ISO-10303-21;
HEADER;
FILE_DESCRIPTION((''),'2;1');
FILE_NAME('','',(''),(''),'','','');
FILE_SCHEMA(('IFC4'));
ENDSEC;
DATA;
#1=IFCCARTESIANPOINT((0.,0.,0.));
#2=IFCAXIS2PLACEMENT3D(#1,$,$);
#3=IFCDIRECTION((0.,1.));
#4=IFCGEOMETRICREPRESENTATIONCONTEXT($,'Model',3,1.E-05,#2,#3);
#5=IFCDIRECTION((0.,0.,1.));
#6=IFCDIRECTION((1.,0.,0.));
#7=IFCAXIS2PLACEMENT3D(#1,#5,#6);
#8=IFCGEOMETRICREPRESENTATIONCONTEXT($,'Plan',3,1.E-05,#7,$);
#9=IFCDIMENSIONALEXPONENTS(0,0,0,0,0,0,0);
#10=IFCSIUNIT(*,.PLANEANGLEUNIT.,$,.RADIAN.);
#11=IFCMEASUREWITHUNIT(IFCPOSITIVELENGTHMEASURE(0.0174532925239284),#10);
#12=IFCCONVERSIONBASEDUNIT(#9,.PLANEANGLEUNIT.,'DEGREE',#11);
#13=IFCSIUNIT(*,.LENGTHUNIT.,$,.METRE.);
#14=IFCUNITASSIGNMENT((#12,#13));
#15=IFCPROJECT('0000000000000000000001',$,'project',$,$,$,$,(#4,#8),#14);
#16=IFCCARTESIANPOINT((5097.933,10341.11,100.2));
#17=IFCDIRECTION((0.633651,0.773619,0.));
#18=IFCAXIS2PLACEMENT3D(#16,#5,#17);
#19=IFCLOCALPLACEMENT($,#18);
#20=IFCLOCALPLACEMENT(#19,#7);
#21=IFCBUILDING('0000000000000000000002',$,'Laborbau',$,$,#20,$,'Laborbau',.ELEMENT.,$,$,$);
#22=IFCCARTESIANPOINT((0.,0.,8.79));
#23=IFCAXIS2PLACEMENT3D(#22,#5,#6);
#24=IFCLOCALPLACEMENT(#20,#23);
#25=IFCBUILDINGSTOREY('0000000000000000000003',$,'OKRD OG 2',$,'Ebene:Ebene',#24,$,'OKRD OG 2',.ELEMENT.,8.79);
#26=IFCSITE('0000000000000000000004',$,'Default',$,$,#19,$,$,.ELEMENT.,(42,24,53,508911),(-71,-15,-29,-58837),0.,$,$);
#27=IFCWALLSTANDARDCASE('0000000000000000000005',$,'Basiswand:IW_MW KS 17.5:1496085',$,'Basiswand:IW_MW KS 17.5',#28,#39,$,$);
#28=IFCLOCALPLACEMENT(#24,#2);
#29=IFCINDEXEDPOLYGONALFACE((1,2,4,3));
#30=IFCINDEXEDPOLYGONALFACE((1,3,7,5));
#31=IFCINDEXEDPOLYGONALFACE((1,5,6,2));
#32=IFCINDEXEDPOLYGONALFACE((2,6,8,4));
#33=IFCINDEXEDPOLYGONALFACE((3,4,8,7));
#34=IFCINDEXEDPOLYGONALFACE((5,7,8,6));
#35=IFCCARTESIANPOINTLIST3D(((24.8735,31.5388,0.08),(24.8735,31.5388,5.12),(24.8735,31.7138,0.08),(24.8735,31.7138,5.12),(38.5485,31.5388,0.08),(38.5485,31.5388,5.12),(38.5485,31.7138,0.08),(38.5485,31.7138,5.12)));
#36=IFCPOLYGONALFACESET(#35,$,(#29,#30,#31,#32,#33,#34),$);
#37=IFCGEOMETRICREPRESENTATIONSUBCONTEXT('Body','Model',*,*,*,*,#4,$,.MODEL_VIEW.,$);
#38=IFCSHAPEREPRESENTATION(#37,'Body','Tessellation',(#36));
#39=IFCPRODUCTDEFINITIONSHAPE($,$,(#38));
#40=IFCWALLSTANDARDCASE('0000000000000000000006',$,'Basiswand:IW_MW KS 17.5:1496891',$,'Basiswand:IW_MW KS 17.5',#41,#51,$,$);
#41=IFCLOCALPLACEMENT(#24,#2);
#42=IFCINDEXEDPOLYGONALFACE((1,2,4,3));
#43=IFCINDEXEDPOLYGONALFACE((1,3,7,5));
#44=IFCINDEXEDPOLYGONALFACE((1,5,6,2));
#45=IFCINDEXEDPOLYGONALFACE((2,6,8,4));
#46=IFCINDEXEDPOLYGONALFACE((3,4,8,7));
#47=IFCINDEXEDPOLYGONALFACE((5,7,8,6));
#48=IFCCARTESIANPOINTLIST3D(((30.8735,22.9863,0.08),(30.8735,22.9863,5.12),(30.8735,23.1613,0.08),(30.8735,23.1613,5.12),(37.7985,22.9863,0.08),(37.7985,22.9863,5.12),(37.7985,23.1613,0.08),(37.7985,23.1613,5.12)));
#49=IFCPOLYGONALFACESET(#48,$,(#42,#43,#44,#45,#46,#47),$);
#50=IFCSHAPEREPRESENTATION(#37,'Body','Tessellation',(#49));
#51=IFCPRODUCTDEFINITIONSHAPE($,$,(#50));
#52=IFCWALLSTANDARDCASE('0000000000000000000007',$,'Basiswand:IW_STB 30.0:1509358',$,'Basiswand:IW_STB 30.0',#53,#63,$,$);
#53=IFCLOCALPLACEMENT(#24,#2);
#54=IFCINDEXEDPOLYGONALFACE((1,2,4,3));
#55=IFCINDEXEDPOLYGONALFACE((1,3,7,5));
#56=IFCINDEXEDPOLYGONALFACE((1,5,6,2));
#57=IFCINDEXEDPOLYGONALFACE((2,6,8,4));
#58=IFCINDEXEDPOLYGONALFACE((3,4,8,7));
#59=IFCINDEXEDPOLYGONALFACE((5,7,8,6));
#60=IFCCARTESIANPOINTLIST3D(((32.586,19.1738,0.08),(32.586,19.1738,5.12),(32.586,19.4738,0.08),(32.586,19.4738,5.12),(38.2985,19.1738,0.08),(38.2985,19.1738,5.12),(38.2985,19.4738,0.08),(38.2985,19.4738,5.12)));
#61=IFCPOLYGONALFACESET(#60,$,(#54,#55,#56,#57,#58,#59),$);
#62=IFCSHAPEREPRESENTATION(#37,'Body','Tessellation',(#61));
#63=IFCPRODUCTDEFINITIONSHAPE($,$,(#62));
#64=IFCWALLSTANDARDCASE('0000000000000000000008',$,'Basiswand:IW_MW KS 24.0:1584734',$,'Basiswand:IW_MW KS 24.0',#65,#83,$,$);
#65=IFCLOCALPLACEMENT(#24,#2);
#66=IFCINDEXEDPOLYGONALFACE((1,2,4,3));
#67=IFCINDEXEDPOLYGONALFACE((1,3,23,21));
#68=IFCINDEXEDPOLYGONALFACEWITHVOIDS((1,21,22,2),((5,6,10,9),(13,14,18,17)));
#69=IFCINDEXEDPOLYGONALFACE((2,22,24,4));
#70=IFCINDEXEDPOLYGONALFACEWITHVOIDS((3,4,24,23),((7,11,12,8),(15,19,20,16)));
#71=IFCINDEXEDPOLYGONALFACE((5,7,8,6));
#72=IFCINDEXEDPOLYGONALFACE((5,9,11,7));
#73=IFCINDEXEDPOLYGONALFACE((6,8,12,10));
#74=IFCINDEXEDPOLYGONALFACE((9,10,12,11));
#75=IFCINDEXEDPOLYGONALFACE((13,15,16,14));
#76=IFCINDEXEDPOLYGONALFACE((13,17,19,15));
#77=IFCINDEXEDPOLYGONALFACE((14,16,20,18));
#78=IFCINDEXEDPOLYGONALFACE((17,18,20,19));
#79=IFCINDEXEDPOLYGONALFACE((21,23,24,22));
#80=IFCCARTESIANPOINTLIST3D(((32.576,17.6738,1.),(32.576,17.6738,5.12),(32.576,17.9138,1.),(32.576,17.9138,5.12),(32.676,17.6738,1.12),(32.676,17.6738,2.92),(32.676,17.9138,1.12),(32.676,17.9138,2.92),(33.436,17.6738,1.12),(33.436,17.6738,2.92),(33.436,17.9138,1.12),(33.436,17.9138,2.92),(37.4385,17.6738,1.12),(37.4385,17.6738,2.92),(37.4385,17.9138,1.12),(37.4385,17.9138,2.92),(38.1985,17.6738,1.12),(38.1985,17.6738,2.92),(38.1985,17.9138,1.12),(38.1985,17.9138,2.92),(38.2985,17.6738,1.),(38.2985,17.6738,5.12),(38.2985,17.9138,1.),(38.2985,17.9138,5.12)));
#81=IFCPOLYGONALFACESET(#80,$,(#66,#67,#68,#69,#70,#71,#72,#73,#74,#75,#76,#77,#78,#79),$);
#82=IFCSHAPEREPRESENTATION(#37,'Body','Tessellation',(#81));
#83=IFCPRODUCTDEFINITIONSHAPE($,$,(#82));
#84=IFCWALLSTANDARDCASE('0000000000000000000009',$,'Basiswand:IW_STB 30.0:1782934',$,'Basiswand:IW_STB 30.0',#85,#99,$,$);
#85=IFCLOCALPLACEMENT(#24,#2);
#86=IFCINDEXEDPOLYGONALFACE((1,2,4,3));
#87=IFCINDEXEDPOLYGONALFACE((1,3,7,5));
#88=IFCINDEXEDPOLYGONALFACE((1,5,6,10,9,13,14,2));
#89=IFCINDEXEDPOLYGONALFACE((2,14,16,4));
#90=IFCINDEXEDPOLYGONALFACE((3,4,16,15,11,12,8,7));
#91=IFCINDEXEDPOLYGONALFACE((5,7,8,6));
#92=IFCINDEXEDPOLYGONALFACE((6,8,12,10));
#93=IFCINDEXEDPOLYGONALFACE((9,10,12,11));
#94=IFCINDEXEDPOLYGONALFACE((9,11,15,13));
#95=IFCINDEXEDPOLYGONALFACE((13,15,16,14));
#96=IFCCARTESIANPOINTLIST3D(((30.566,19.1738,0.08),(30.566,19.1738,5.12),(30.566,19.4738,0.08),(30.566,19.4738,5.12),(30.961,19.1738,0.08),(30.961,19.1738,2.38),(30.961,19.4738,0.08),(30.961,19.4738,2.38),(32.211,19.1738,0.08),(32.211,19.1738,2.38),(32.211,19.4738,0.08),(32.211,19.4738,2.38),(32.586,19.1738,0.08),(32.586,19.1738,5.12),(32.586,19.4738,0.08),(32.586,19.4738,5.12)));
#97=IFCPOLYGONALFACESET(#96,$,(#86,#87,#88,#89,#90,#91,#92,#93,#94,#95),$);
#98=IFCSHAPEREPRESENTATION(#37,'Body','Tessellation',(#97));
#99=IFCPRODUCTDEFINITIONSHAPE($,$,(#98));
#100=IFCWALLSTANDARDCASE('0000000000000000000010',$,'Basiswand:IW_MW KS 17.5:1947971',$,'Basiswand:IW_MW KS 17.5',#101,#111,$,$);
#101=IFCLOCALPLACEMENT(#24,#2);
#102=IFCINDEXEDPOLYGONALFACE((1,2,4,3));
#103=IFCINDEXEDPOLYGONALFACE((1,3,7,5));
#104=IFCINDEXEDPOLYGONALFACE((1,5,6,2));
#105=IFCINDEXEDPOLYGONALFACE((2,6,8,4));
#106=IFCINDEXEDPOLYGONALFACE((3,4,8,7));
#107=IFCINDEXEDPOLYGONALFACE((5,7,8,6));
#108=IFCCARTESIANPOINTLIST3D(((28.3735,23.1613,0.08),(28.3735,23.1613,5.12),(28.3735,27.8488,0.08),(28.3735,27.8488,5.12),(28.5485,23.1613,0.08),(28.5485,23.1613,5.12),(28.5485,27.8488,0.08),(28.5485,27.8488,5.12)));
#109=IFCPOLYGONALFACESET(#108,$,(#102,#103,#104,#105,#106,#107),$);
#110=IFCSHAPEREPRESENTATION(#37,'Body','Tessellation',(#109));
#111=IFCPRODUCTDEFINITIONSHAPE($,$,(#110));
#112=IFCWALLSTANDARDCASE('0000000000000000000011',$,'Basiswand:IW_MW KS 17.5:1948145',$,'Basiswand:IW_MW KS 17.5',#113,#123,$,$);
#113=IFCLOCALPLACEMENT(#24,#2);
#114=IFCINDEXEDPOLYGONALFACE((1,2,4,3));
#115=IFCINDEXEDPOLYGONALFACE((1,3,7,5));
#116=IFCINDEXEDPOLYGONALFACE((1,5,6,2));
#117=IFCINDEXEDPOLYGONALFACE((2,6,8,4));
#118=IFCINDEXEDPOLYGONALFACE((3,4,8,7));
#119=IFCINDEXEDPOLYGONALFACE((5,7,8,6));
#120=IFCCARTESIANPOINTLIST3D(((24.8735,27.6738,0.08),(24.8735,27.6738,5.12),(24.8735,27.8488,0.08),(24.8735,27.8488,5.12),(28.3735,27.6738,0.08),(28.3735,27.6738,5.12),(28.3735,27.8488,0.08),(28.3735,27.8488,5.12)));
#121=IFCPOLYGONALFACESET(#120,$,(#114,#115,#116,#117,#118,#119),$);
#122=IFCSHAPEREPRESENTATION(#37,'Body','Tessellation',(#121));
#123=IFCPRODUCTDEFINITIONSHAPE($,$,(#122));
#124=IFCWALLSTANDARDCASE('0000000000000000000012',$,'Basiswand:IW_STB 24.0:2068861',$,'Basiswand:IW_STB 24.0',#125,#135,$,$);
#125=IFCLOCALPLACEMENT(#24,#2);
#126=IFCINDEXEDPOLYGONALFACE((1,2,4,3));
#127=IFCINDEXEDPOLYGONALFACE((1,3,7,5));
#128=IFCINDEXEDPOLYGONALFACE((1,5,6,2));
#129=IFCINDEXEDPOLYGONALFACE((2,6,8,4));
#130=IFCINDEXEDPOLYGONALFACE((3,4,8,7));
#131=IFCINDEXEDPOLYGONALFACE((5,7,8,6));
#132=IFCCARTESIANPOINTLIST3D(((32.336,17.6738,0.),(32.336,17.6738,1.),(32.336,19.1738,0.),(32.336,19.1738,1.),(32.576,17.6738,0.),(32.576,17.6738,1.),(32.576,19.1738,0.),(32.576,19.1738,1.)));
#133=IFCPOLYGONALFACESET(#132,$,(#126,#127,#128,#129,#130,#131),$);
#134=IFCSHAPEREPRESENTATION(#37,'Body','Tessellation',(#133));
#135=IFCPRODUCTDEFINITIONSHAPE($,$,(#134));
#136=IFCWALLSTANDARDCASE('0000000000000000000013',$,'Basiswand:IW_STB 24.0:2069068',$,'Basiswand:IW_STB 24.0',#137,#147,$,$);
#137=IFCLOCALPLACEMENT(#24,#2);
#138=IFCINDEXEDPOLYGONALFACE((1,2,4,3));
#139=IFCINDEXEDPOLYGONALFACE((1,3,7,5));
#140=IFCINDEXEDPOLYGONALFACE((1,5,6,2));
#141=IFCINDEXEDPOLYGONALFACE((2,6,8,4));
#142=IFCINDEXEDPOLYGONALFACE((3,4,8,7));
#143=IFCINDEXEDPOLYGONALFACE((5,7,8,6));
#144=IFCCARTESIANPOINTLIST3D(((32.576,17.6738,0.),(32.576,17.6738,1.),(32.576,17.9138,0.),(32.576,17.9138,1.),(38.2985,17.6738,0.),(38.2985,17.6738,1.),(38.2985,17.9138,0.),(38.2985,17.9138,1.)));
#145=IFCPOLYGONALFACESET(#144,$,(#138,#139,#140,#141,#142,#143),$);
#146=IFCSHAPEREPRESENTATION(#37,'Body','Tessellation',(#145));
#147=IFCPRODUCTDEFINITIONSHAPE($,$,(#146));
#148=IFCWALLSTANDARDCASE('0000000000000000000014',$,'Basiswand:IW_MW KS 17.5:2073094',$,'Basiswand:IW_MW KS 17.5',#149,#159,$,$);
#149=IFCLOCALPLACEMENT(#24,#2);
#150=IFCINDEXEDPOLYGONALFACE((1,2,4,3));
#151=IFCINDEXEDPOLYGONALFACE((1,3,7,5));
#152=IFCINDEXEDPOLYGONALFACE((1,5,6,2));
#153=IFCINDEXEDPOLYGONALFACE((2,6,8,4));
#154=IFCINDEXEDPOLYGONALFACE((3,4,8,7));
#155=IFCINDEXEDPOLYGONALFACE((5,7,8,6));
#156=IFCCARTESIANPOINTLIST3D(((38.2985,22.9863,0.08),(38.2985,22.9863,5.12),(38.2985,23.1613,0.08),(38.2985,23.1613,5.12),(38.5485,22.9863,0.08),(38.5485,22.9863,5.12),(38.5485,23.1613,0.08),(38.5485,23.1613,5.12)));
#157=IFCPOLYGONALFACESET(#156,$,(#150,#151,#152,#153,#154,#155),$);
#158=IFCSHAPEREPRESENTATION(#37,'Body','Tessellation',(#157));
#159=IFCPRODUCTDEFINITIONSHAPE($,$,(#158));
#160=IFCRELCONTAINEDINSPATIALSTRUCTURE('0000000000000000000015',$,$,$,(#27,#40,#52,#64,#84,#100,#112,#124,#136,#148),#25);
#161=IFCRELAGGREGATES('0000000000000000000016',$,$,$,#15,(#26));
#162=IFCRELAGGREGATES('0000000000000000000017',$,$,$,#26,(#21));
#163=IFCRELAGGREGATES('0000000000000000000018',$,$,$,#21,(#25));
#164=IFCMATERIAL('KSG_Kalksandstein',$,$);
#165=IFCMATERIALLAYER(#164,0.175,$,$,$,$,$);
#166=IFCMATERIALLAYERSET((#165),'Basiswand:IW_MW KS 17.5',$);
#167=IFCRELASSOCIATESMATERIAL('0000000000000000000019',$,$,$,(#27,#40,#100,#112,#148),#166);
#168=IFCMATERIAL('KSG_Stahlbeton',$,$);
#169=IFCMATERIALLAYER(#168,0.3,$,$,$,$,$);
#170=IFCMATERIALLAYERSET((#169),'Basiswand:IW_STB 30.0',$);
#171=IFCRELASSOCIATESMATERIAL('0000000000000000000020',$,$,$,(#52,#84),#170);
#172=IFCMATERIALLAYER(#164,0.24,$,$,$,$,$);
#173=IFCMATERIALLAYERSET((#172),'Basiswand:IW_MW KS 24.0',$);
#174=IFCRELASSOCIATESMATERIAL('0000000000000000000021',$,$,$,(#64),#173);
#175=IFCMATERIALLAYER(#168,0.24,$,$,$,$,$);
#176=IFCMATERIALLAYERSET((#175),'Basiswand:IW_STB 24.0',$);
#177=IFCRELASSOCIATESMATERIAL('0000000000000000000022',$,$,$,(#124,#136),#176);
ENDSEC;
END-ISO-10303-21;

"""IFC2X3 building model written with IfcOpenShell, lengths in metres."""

from ifc_helpers import new_model, entity, si_unit, converted_unit, direction, frame, frame_2d, origin, origin_with_axes, place, context, subcontext, project, spatial, rectangle, extrude, material, layer, layer_set, layer_usage, element, save


model = new_model("IFC2X3")

# Units and contexts
model_context = context("Model", 3, precision=1e-05, world=origin(), true_north=direction((0.0, 1.0)))
plan_context = context("Plan", 3, precision=1e-05, world=origin_with_axes())
body_context = subcontext(model_context, "Body", "Model", "MODEL_VIEW")
ifc_project = project(units=[converted_unit("PLANEANGLEUNIT", "DEGREE", entity("IfcPositiveLengthMeasure", 0.0174532925239284), si_unit("PLANEANGLEUNIT", "RADIAN"), dimensions=[0, 0, 0, 0, 0, 0, 0]), si_unit("LENGTHUNIT", "METRE")], contexts=[model_context, plan_context])

# Site, building, storey
site_placement = place(None, frame((5097.933, 10341.11, 100.2), z_axis=(0.0, 0.0, 1.0), x_axis=(0.633651, 0.773619, 0.0)))
site = spatial("IfcSite", under=ifc_project, at=site_placement, Name="Default", CompositionType="ELEMENT", RefLatitude=(42, 24, 53, 508911), RefLongitude=(-71, -15, -29, -58837), RefElevation=0.0)
building_placement = place(site_placement, origin_with_axes())
building = spatial("IfcBuilding", under=site, at=building_placement, Name="Laborbau", LongName="Laborbau", CompositionType="ELEMENT")
storey_placement = place(building_placement, frame((0.0, 0.0, 8.79), z_axis=(0.0, 0.0, 1.0), x_axis=(1.0, 0.0, 0.0)))
storey = spatial("IfcBuildingStorey", under=building, at=storey_placement, Name="OKRD OG 2", ObjectType="Ebene:Ebene", LongName="OKRD OG 2", CompositionType="ELEMENT", Elevation=8.79)

# Walls
ifc_material_1 = material(Name="KSG_Kalksandstein")
ifc_layer_1 = layer(ifc_material_1, 0.175)
ifc_layer_set_1 = layer_set([ifc_layer_1], Name="Basiswand:IW_MW KS 17.5")
ifc_layer_usage_1 = layer_usage(ifc_layer_set_1, "AXIS2", "NEGATIVE", 0.0875)
wall_1_placement = place(storey_placement, frame((24.8735, 31.6263, 0.08), z_axis=(0.0, 0.0, 1.0), x_axis=(1.0, 0.0, 0.0)))
element("IfcWallStandardCase", 1, at=wall_1_placement, inside=storey, material=ifc_layer_usage_1, Name="Basiswand:IW_MW KS 17.5:1496085", ObjectType="Basiswand:IW_MW KS 17.5", context=body_context, shape_type="SweptSolid", body=[
    extrude(rectangle(XDim=13.675, YDim=0.175, at=frame_2d((6.8375, 0.0), x_axis=(-1.0, 0.0))), origin(), (0.0, 0.0, 1.0), 5.04),
])
ifc_layer_usage_2 = layer_usage(ifc_layer_set_1, "AXIS2", "NEGATIVE", 0.0875)
wall_2_placement = place(storey_placement, frame((30.8735, 23.0738, 0.08), z_axis=(0.0, 0.0, 1.0), x_axis=(1.0, 0.0, 0.0)))
element("IfcWallStandardCase", 2, at=wall_2_placement, inside=storey, material=ifc_layer_usage_2, Name="Basiswand:IW_MW KS 17.5:1496891", ObjectType="Basiswand:IW_MW KS 17.5", context=body_context, shape_type="SweptSolid", body=[
    extrude(rectangle(XDim=6.925, YDim=0.175, at=frame_2d((3.4625, 0.0), x_axis=(-1.0, 0.0))), origin(), (0.0, 0.0, 1.0), 5.04),
])
ifc_material_2 = material(Name="KSG_Stahlbeton")
ifc_layer_2 = layer(ifc_material_2, 0.3)
ifc_layer_set_2 = layer_set([ifc_layer_2], Name="Basiswand:IW_STB 30.0")
ifc_layer_usage_3 = layer_usage(ifc_layer_set_2, "AXIS2", "POSITIVE", -0.15)
wall_3_placement = place(storey_placement, frame((38.2985, 19.3238, 0.08), z_axis=(0.0, 0.0, 1.0), x_axis=(-1.0, 0.0, 0.0)))
element("IfcWallStandardCase", 3, at=wall_3_placement, inside=storey, material=ifc_layer_usage_3, Name="Basiswand:IW_STB 30.0:1509358", ObjectType="Basiswand:IW_STB 30.0", context=body_context, shape_type="SweptSolid", body=[
    extrude(rectangle(XDim=5.7125, YDim=0.3, at=frame_2d((2.8563, 0.0), x_axis=(-1.0, 0.0))), origin(), (0.0, 0.0, 1.0), 5.04),
])

# Walls, openings
ifc_layer_3 = layer(ifc_material_1, 0.24)
ifc_layer_set_3 = layer_set([ifc_layer_3], Name="Basiswand:IW_MW KS 24.0")
ifc_layer_usage_4 = layer_usage(ifc_layer_set_3, "AXIS2", "POSITIVE", -0.12)
wall_4_placement = place(storey_placement, frame((32.576, 17.7938, 1.0), z_axis=(0.0, 0.0, 1.0), x_axis=(1.0, 0.0, 0.0)))
wall_4 = element("IfcWallStandardCase", 4, at=wall_4_placement, inside=storey, material=ifc_layer_usage_4, Name="Basiswand:IW_MW KS 24.0:1584734", ObjectType="Basiswand:IW_MW KS 24.0", context=body_context, shape_type="SweptSolid", body=[
    extrude(rectangle(XDim=5.7225, YDim=0.24, at=frame_2d((2.8613, 0.0), x_axis=(-1.0, 0.0))), origin(), (0.0, 0.0, 1.0), 4.12),
])
opening_1_placement = place(wall_4_placement, frame((-32.576, -17.7938, -1.0), z_axis=(0.0, 0.0, 1.0), x_axis=(1.0, 0.0, 0.0)))
element("IfcOpeningElement", 5, at=opening_1_placement, cuts=wall_4, ObjectType="Opening", context=body_context, shape_type="SweptSolid", body=[
    extrude(rectangle(XDim=1.8, YDim=0.76, at=frame_2d((0.0, 0.0), x_axis=(1.0, 0.0))), frame((37.8185, 16.3898, 2.02), z_axis=(0.0, 1.0, 0.0), x_axis=(0.0, 0.0, 1.0)), (0.0, 0.0, 1.0), 3.048),
])
opening_2_placement = place(wall_4_placement, frame((5.6225, 0.12, 0.12), z_axis=(0.0, 0.0, 1.0), x_axis=(1.0, 0.0, 0.0)))
element("IfcOpeningElement", 6, at=opening_2_placement, cuts=wall_4, ObjectType="Opening", context=body_context, shape_type="SweptSolid", body=[
    extrude(rectangle(XDim=1.8, YDim=0.76, at=frame_2d((0.9, 0.38), x_axis=(1.0, 0.0))), frame((0.0, 0.0, 0.0), z_axis=(0.0, -1.0, 0.0), x_axis=(0.0, 0.0, 1.0)), (0.0, 0.0, 1.0), 0.24),
])
opening_3_placement = place(wall_4_placement, frame((-32.576, -17.7938, -1.0), z_axis=(0.0, 0.0, 1.0), x_axis=(1.0, 0.0, 0.0)))
element("IfcOpeningElement", 7, at=opening_3_placement, cuts=wall_4, ObjectType="Opening", context=body_context, shape_type="SweptSolid", body=[
    extrude(rectangle(XDim=1.8, YDim=0.76, at=frame_2d((0.0, 0.0), x_axis=(0.0, 1.0))), frame((33.056, 16.3898, 2.02), z_axis=(0.0, 1.0, 0.0), x_axis=(-1.0, 0.0, 0.0)), (0.0, 0.0, 1.0), 3.048),
])
opening_4_placement = place(wall_4_placement, frame((0.86, 0.12, 0.12), z_axis=(0.0, 0.0, 1.0), x_axis=(1.0, 0.0, 0.0)))
element("IfcOpeningElement", 8, at=opening_4_placement, cuts=wall_4, ObjectType="Opening", context=body_context, shape_type="SweptSolid", body=[
    extrude(rectangle(XDim=1.8, YDim=0.76, at=frame_2d((0.9, 0.38), x_axis=(1.0, 0.0))), frame((0.0, 0.0, 0.0), z_axis=(0.0, -1.0, 0.0), x_axis=(0.0, 0.0, 1.0)), (0.0, 0.0, 1.0), 0.24),
])
ifc_layer_usage_5 = layer_usage(ifc_layer_set_2, "AXIS2", "POSITIVE", -0.15)
wall_5_placement = place(storey_placement, frame((32.586, 19.3238, 0.08), z_axis=(0.0, 0.0, 1.0), x_axis=(-1.0, 0.0, 0.0)))
wall_5 = element("IfcWallStandardCase", 9, at=wall_5_placement, inside=storey, material=ifc_layer_usage_5, Name="Basiswand:IW_STB 30.0:1782934", ObjectType="Basiswand:IW_STB 30.0", context=body_context, shape_type="SweptSolid", body=[
    extrude(rectangle(XDim=2.02, YDim=0.3, at=frame_2d((1.01, 0.0), x_axis=(-1.0, 0.0))), origin(), (0.0, 0.0, 1.0), 5.04),
])
opening_5_placement = place(wall_5_placement, frame((0.375, -0.15, -0.08), z_axis=(0.0, 0.0, 1.0), x_axis=(1.0, 0.0, 0.0)))
element("IfcOpeningElement", 10, at=opening_5_placement, cuts=wall_5, ObjectType="Opening", context=body_context, shape_type="SweptSolid", body=[
    extrude(rectangle(XDim=2.38, YDim=1.25, at=frame_2d((1.19, 0.625), x_axis=(1.0, 0.0))), frame((0.0, 0.0, 0.0), z_axis=(0.0, 1.0, 0.0), x_axis=(0.0, 0.0, 1.0)), (0.0, 0.0, 1.0), 0.3),
])
opening_6_placement = place(wall_5_placement, frame((32.586, 19.3238, -0.08), z_axis=(0.0, 0.0, 1.0), x_axis=(-1.0, 0.0, 0.0)))
element("IfcOpeningElement", 11, at=opening_6_placement, cuts=wall_5, ObjectType="Opening", context=body_context, shape_type="SweptSolid", body=[
    extrude(rectangle(XDim=2.38, YDim=1.25, at=frame_2d((0.0, 0.0), x_axis=(0.0, 1.0))), frame((31.586, 20.9978, 1.19), z_axis=(0.0, -1.0, 0.0), x_axis=(1.0, 0.0, 0.0)), (0.0, 0.0, 1.0), 3.048),
])

# Walls
ifc_layer_usage_6 = layer_usage(ifc_layer_set_1, "AXIS2", "NEGATIVE", 0.0875)
wall_6_placement = place(storey_placement, frame((28.461, 23.1613, 0.08), z_axis=(0.0, 0.0, 1.0), x_axis=(0.0, 1.0, 0.0)))
element("IfcWallStandardCase", 12, at=wall_6_placement, inside=storey, material=ifc_layer_usage_6, Name="Basiswand:IW_MW KS 17.5:1947971", ObjectType="Basiswand:IW_MW KS 17.5", context=body_context, shape_type="SweptSolid", body=[
    extrude(rectangle(XDim=4.6875, YDim=0.175, at=frame_2d((2.3438, 0.0), x_axis=(-1.0, 0.0))), origin(), (0.0, 0.0, 1.0), 5.04),
])
ifc_layer_usage_7 = layer_usage(ifc_layer_set_1, "AXIS2", "NEGATIVE", 0.0875)
wall_7_placement = place(storey_placement, frame((24.8735, 27.7613, 0.08), z_axis=(0.0, 0.0, 1.0), x_axis=(1.0, 0.0, 0.0)))
element("IfcWallStandardCase", 13, at=wall_7_placement, inside=storey, material=ifc_layer_usage_7, Name="Basiswand:IW_MW KS 17.5:1948145", ObjectType="Basiswand:IW_MW KS 17.5", context=body_context, shape_type="SweptSolid", body=[
    extrude(rectangle(XDim=3.5, YDim=0.175, at=frame_2d((1.75, 0.0), x_axis=(-1.0, 0.0))), origin(), (0.0, 0.0, 1.0), 5.04),
])
ifc_layer_4 = layer(ifc_material_2, 0.24)
ifc_layer_set_4 = layer_set([ifc_layer_4], Name="Basiswand:IW_STB 24.0")
ifc_layer_usage_8 = layer_usage(ifc_layer_set_4, "AXIS2", "NEGATIVE", 0.12)
wall_8_placement = place(storey_placement, frame((32.456, 19.1738, 0.0), z_axis=(0.0, 0.0, 1.0), x_axis=(0.0, -1.0, 0.0)))
element("IfcWallStandardCase", 14, at=wall_8_placement, inside=storey, material=ifc_layer_usage_8, Name="Basiswand:IW_STB 24.0:2068861", ObjectType="Basiswand:IW_STB 24.0", context=body_context, shape_type="SweptSolid", body=[
    extrude(rectangle(XDim=1.5, YDim=0.24, at=frame_2d((0.75, 0.0), x_axis=(-1.0, 0.0))), origin(), (0.0, 0.0, 1.0), 1.0),
])
ifc_layer_usage_9 = layer_usage(ifc_layer_set_4, "AXIS2", "NEGATIVE", 0.12)
wall_9_placement = place(storey_placement, frame((32.576, 17.7938, 0.0), z_axis=(0.0, 0.0, 1.0), x_axis=(1.0, 0.0, 0.0)))
element("IfcWallStandardCase", 15, at=wall_9_placement, inside=storey, material=ifc_layer_usage_9, Name="Basiswand:IW_STB 24.0:2069068", ObjectType="Basiswand:IW_STB 24.0", context=body_context, shape_type="SweptSolid", body=[
    extrude(rectangle(XDim=5.7225, YDim=0.24, at=frame_2d((2.8613, 0.0), x_axis=(-1.0, 0.0))), origin(), (0.0, 0.0, 1.0), 1.0),
])
ifc_layer_usage_10 = layer_usage(ifc_layer_set_1, "AXIS2", "NEGATIVE", 0.0875)
wall_10_placement = place(storey_placement, frame((38.5485, 23.0738, 0.08), z_axis=(0.0, 0.0, 1.0), x_axis=(-1.0, 0.0, 0.0)))
element("IfcWallStandardCase", 16, at=wall_10_placement, inside=storey, material=ifc_layer_usage_10, Name="Basiswand:IW_MW KS 17.5:2073094", ObjectType="Basiswand:IW_MW KS 17.5", context=body_context, shape_type="SweptSolid", body=[
    extrude(rectangle(XDim=0.25, YDim=0.175, at=frame_2d((0.125, 0.0), x_axis=(-1.0, 0.0))), origin(), (0.0, 0.0, 1.0), 5.04),
])

save(model, "model.ifc")
